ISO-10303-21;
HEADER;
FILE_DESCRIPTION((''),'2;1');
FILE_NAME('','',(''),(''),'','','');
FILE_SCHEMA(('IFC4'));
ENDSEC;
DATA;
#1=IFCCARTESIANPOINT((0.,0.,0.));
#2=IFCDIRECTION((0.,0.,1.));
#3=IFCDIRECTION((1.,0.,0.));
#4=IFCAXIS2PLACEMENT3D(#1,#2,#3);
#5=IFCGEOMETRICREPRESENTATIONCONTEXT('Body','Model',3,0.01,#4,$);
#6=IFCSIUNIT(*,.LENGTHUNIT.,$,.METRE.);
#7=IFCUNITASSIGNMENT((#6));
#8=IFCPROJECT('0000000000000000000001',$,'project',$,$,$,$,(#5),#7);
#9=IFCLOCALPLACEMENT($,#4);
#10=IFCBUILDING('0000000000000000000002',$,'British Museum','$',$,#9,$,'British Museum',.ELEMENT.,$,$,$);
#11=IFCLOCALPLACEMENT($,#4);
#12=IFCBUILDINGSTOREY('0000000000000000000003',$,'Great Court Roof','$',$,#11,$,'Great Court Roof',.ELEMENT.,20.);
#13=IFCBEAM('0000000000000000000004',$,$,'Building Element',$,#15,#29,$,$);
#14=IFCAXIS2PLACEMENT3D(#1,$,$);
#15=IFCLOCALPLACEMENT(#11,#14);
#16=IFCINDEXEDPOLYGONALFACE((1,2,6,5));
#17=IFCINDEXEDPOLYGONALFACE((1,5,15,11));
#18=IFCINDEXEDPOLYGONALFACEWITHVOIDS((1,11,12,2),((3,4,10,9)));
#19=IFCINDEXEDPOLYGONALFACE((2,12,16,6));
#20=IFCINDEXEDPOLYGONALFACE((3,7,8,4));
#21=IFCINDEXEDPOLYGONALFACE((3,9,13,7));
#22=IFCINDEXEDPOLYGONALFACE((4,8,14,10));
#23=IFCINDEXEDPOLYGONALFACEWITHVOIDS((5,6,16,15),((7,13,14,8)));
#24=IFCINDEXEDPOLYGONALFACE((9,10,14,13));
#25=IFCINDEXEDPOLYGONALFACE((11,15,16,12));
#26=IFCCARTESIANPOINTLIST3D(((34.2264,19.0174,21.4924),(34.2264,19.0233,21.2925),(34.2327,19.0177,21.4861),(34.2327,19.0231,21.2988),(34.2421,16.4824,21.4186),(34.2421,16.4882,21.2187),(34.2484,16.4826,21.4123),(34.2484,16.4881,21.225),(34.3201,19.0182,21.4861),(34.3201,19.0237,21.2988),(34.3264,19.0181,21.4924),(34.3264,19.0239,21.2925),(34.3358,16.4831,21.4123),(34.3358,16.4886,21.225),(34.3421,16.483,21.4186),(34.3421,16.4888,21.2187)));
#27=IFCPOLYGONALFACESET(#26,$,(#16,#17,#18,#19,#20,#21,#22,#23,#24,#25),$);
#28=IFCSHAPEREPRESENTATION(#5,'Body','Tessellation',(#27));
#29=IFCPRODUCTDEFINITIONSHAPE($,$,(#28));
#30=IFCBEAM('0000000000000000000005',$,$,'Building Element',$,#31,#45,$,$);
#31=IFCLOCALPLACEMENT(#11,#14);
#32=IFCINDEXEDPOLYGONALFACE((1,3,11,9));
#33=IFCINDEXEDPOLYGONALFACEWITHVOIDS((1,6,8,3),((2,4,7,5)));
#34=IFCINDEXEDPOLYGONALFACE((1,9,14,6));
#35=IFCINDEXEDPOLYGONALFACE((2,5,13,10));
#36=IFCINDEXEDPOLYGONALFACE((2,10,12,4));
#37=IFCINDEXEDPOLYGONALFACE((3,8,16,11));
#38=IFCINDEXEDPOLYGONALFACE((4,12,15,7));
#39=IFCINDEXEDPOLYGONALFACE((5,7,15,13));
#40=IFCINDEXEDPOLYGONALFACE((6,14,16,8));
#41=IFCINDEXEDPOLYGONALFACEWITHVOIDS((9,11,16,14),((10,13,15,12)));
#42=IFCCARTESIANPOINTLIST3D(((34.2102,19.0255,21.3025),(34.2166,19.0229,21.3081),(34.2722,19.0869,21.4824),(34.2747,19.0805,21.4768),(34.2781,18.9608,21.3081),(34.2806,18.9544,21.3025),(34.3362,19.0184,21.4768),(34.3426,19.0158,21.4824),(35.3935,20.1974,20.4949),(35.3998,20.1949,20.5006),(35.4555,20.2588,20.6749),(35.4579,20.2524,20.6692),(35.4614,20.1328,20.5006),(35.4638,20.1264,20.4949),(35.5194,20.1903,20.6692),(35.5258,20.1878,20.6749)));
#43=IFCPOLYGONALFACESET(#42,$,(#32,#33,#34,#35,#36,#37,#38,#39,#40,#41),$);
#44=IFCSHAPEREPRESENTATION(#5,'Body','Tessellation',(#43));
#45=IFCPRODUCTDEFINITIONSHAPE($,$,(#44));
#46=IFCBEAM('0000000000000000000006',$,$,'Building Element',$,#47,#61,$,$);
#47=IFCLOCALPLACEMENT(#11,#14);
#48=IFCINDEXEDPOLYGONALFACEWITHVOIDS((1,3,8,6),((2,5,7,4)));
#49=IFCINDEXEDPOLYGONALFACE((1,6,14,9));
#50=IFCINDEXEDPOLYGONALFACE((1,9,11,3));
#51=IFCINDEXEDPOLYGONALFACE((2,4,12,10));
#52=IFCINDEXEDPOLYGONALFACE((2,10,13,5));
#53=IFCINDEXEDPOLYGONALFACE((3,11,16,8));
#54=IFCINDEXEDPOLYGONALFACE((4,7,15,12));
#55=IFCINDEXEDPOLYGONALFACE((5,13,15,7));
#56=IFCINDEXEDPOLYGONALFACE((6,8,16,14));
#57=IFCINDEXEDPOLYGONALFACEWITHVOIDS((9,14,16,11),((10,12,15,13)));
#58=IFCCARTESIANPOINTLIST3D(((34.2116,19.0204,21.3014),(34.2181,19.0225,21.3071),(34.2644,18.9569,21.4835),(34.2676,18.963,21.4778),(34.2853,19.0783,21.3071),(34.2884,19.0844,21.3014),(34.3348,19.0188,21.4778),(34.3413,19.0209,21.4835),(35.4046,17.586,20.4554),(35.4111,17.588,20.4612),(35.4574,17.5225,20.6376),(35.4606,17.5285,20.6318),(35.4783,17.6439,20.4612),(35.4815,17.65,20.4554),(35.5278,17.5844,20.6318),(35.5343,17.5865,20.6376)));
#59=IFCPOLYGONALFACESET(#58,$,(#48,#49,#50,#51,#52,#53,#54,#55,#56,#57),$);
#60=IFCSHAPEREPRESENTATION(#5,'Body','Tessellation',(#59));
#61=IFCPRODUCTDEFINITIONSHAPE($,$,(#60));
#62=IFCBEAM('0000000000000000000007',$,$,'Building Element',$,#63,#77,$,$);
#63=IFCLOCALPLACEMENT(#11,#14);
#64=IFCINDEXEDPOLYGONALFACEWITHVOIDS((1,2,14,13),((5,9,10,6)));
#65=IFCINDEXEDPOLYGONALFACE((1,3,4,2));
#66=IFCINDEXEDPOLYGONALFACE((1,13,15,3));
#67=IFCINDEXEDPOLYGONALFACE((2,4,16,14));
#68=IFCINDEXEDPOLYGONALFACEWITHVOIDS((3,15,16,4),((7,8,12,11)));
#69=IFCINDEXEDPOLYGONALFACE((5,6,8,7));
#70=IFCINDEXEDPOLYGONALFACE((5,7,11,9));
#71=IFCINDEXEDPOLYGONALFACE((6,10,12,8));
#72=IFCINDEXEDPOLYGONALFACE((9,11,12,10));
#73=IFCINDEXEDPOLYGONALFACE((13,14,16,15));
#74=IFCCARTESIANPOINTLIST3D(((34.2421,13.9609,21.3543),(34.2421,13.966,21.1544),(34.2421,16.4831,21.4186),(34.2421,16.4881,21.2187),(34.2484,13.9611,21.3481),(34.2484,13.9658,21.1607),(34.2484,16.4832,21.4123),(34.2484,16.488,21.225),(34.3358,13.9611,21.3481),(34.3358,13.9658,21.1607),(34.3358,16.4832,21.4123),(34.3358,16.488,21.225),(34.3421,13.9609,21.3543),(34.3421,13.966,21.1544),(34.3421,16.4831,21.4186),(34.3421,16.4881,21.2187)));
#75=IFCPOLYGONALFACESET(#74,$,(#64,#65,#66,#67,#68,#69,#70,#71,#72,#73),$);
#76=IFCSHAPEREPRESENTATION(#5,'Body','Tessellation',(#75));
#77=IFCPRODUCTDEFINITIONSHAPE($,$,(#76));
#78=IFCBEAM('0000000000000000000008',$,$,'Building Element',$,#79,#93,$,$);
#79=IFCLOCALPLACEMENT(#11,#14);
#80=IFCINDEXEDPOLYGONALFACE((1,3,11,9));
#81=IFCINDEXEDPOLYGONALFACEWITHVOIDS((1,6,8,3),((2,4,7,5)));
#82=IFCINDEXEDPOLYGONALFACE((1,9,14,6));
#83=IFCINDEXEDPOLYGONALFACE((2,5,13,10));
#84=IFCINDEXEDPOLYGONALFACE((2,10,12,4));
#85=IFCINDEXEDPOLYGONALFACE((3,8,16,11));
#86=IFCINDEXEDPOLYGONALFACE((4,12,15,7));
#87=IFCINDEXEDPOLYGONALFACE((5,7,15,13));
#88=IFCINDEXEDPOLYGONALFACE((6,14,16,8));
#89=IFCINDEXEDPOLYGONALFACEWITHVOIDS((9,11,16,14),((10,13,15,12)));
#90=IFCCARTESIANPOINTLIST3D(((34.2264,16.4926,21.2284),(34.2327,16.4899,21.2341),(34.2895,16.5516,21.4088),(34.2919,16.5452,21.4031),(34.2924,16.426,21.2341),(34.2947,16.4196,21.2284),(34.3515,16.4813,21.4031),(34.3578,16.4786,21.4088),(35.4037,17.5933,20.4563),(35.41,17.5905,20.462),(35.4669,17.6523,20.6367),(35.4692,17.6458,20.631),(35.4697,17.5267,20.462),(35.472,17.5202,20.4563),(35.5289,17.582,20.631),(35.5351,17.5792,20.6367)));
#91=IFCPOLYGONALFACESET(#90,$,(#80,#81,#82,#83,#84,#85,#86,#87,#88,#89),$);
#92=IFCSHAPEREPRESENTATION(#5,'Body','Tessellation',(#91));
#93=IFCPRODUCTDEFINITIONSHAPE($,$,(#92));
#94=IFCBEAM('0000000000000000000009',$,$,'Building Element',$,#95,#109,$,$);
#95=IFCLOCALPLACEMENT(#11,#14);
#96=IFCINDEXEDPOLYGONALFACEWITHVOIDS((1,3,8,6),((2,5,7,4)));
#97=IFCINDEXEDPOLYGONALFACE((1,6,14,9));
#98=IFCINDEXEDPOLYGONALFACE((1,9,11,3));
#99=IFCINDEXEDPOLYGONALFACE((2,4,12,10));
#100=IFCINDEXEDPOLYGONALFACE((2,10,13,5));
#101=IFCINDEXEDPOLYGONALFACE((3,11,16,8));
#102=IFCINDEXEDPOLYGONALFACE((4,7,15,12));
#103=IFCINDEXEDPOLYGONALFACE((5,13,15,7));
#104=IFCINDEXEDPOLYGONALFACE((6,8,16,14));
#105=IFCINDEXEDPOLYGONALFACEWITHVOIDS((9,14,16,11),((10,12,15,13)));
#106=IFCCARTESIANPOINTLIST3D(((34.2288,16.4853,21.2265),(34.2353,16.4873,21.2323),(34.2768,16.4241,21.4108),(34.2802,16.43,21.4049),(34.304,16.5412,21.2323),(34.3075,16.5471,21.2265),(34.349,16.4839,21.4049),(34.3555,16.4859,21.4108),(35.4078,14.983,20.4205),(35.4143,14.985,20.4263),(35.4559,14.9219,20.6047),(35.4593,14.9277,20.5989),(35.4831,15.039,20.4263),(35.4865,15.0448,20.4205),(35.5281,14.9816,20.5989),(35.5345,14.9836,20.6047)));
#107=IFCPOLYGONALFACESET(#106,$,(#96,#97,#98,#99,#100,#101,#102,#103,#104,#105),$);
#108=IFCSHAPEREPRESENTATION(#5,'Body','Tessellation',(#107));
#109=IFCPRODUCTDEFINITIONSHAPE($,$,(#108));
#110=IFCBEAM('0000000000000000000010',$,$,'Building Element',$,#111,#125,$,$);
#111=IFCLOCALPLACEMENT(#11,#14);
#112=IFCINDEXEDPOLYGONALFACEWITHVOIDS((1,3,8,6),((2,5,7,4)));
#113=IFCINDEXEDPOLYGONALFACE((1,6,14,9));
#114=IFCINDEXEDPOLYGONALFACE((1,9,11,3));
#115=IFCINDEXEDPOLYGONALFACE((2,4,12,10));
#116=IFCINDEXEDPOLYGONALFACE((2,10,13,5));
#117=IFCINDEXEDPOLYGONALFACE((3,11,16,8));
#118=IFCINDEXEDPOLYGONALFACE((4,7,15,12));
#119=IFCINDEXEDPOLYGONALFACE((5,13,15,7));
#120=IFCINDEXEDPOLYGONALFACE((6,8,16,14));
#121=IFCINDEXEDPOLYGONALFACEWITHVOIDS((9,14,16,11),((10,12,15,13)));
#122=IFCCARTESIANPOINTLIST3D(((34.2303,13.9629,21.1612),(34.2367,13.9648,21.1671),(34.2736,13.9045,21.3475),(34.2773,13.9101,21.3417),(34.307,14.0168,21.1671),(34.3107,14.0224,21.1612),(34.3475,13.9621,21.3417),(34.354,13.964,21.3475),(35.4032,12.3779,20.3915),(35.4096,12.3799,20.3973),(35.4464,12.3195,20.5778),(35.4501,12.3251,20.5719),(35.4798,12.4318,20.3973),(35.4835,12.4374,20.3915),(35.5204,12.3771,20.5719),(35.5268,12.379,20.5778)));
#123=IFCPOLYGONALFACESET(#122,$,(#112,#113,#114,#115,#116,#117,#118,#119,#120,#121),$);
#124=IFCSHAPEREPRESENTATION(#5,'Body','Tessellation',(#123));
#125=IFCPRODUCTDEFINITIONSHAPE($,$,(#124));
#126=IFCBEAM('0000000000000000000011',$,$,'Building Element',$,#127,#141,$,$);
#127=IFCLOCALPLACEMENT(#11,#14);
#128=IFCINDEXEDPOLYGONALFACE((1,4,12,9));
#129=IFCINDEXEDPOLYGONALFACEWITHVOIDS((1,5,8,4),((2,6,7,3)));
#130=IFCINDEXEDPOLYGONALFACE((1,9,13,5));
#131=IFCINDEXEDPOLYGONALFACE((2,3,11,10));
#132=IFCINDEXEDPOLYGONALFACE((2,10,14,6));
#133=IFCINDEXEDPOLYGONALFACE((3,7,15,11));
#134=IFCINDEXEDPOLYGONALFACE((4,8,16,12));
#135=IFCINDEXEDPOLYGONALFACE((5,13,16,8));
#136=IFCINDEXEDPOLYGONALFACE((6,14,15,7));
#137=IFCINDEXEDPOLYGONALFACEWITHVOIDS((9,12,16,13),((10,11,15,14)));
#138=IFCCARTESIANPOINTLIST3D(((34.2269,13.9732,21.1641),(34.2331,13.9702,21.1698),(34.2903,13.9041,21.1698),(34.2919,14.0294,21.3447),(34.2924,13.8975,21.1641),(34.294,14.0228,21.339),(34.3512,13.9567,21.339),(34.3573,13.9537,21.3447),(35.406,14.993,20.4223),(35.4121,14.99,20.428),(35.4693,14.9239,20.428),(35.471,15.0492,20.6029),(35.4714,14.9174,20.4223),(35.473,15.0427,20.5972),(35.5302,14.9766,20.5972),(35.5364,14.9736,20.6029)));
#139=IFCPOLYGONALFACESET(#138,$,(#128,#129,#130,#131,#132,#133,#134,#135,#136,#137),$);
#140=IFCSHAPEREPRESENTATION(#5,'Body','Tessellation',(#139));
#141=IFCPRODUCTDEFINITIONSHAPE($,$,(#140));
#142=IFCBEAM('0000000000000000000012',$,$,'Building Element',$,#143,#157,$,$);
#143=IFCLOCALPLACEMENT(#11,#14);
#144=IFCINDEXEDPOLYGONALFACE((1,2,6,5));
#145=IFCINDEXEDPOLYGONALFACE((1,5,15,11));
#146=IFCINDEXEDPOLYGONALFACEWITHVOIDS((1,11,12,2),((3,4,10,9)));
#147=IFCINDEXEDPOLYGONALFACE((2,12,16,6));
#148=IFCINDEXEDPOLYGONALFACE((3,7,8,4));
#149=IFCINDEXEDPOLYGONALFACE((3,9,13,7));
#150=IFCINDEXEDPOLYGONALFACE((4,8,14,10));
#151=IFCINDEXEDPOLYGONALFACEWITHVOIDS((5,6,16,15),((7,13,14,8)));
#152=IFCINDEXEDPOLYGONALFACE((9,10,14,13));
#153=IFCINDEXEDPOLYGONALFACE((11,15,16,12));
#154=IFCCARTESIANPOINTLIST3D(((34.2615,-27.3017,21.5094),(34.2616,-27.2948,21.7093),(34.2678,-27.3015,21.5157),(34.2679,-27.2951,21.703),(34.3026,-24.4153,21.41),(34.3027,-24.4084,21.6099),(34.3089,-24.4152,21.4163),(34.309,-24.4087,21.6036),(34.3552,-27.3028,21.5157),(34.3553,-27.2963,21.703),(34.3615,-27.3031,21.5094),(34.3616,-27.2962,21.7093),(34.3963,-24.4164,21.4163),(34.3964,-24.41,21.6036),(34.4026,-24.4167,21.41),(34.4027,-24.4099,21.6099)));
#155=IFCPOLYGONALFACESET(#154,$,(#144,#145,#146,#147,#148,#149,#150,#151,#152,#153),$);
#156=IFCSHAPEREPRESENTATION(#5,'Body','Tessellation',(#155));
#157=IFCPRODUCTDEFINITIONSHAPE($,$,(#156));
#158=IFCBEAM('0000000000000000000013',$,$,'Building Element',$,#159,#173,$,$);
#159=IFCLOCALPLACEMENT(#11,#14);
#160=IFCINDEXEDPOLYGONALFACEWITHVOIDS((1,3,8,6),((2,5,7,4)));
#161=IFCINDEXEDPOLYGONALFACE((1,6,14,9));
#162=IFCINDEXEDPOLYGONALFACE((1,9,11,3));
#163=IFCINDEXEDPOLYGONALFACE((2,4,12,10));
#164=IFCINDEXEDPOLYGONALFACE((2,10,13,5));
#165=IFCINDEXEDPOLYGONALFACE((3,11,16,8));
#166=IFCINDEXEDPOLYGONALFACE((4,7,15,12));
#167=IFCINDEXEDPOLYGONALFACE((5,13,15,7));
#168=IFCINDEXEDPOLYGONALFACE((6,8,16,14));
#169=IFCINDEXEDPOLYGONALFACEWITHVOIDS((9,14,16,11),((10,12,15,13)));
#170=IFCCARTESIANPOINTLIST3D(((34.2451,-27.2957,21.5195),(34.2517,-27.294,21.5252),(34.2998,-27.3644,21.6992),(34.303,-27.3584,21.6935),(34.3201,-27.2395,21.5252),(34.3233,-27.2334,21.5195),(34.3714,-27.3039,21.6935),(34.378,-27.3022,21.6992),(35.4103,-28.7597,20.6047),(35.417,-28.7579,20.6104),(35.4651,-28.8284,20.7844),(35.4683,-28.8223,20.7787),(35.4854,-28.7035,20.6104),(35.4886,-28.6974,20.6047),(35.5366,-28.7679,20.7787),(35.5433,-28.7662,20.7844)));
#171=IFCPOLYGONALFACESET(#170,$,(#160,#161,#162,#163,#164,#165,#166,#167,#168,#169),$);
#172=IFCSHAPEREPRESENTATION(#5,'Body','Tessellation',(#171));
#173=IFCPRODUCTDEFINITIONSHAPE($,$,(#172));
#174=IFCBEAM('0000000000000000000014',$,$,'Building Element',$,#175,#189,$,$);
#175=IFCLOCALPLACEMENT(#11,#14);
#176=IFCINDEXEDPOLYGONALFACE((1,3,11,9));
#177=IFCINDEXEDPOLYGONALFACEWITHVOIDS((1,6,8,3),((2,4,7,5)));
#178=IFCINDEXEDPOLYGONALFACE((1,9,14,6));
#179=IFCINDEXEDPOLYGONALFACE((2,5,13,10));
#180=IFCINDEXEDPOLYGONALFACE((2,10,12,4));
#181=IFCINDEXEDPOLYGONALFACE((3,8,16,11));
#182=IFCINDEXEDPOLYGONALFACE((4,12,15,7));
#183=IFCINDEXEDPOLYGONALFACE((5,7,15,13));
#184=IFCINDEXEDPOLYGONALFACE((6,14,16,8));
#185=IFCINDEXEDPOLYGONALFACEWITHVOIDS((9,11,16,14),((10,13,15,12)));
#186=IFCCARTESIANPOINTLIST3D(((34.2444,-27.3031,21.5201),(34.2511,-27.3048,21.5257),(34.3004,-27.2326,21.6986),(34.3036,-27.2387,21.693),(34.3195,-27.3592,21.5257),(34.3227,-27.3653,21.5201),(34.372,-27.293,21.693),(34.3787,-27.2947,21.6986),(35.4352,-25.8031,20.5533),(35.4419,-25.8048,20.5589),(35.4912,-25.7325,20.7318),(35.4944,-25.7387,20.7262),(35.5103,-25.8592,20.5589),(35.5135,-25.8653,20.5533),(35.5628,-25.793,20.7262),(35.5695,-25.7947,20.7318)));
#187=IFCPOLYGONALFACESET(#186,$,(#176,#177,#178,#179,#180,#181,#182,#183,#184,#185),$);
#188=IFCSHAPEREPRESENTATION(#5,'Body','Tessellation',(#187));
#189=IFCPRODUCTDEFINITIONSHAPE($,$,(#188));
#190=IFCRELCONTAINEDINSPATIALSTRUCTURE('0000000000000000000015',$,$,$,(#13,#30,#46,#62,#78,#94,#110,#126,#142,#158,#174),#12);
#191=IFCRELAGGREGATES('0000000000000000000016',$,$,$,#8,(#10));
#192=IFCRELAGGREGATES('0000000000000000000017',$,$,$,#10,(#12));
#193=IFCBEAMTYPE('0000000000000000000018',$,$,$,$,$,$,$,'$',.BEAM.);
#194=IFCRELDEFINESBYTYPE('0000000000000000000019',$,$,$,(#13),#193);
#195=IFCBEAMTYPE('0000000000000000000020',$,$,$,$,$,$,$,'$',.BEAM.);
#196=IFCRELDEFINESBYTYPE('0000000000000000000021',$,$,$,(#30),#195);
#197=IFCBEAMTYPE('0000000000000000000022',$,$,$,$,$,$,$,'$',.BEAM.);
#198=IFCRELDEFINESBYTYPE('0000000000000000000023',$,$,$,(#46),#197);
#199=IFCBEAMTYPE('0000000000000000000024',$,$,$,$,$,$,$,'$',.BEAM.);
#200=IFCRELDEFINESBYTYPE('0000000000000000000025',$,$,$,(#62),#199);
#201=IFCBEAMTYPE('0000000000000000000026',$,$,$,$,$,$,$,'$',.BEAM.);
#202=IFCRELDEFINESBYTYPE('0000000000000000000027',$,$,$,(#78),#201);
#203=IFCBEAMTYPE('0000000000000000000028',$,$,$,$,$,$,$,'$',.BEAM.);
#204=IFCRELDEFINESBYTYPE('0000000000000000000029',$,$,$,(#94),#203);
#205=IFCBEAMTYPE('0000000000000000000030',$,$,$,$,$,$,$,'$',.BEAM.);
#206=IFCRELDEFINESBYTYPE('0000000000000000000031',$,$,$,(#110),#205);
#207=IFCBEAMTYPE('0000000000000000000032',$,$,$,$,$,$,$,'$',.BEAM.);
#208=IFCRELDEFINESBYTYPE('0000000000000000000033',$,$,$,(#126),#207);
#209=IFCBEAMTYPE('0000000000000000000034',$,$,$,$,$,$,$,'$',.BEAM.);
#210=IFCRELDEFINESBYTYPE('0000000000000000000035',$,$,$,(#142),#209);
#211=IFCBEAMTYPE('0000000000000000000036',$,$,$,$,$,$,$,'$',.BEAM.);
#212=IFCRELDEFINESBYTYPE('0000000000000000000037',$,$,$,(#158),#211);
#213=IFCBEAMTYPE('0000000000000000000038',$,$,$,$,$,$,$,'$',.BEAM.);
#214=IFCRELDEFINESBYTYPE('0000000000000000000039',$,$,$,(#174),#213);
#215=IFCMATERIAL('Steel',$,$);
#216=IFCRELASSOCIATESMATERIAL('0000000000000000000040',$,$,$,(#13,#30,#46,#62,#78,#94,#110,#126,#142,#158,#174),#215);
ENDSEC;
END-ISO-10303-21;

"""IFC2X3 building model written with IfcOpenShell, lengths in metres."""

from ifc_helpers import new_model, si_unit, frame, origin_with_axes, origin_2d, place, context, project, spatial, hollow_rectangle, extrude, material, type_object, element, save


model = new_model("IFC2X3")

# Units and contexts
model_context = context("Model", 3, precision=0.01, world=origin_with_axes(), identifier="Body")
ifc_project = project(units=[si_unit("LENGTHUNIT", "METRE")], contexts=[model_context])

# Building, storey
building_placement = place(None, origin_with_axes())
building = spatial("IfcBuilding", under=ifc_project, at=building_placement, Name="British Museum", Description="$", LongName="British Museum", CompositionType="ELEMENT")
storey_placement = place(None, origin_with_axes())
storey = spatial("IfcBuildingStorey", under=building, at=storey_placement, Name="Great Court Roof", Description="$", LongName="Great Court Roof", CompositionType="ELEMENT", Elevation=20.0)

# Beams
ifc_material = material(Name="Steel")
beam_type_1 = type_object("IfcBeamType", ElementType="$", PredefinedType="BEAM")
beam_1_placement = place(None, origin_with_axes())
element("IfcBeam", 1, at=beam_1_placement, inside=storey, type_object=beam_type_1, material=ifc_material, Description="Building Element", context=model_context, shape_type="SweptSolid", body=[
    extrude(hollow_rectangle(XDim=0.1, YDim=0.2, WallThickness=0.0063, InnerFilletRadius=-0.0063, OuterFilletRadius=0.0, at=origin_2d()), frame((34.2764, 19.0207, 21.3924), z_axis=(0.006196, -0.999557, -0.029107), x_axis=(0.999981, 0.006198, 0.0)), (0.0, 0.0, 1.0), 2.5362),
])
beam_type_2 = type_object("IfcBeamType", ElementType="$", PredefinedType="BEAM")
beam_2_placement = place(None, origin_with_axes())
element("IfcBeam", 2, at=beam_2_placement, inside=storey, type_object=beam_type_2, material=ifc_material, Description="Building Element", context=model_context, shape_type="SweptSolid", body=[
    extrude(hollow_rectangle(XDim=0.1, YDim=0.2, WallThickness=0.0063, InnerFilletRadius=-0.0063, OuterFilletRadius=0.0, at=origin_2d()), frame((34.2764, 19.0207, 21.3924), z_axis=(0.639296, 0.633198, -0.436304), x_axis=(-0.70371, 0.710487, 0.0)), (0.0, 0.0, 1.0), 1.8508),
])
beam_type_3 = type_object("IfcBeamType", ElementType="$", PredefinedType="BEAM")
beam_3_placement = place(None, origin_with_axes())
element("IfcBeam", 3, at=beam_3_placement, inside=storey, type_object=beam_type_3, material=ifc_material, Description="Building Element", context=model_context, shape_type="SweptSolid", body=[
    extrude(hollow_rectangle(XDim=0.1, YDim=0.2, WallThickness=0.0063, InnerFilletRadius=-0.0063, OuterFilletRadius=0.0, at=origin_2d()), frame((34.2764, 19.0207, 21.3924), z_axis=(0.582379, -0.700216, -0.412956), x_axis=(0.768833, 0.639449, 0.0)), (0.0, 0.0, 1.0), 2.0485),
])
beam_type_4 = type_object("IfcBeamType", ElementType="$", PredefinedType="BEAM")
beam_4_placement = place(None, origin_with_axes())
element("IfcBeam", 4, at=beam_4_placement, inside=storey, type_object=beam_type_4, material=ifc_material, Description="Building Element", context=model_context, shape_type="SweptSolid", body=[
    extrude(hollow_rectangle(XDim=0.1, YDim=0.2, WallThickness=0.0063, InnerFilletRadius=-0.0063, OuterFilletRadius=0.0, at=origin_2d()), frame((34.2921, 16.4856, 21.3186), z_axis=(0.000006, -0.999676, -0.025463), x_axis=(1.0, 0.000006, 0.0)), (0.0, 0.0, 1.0), 2.523),
])
beam_type_5 = type_object("IfcBeamType", ElementType="$", PredefinedType="BEAM")
beam_5_placement = place(None, origin_with_axes())
element("IfcBeam", 5, at=beam_5_placement, inside=storey, type_object=beam_type_5, material=ifc_material, Description="Building Element", context=model_context, shape_type="SweptSolid", body=[
    extrude(hollow_rectangle(XDim=0.1, YDim=0.2, WallThickness=0.0063, InnerFilletRadius=-0.0063, OuterFilletRadius=0.0, at=origin_2d()), frame((34.2921, 16.4856, 21.3186), z_axis=(0.658793, 0.615882, -0.432066), x_axis=(-0.682916, 0.730497, 0.0)), (0.0, 0.0, 1.0), 1.7871),
])
beam_type_6 = type_object("IfcBeamType", ElementType="$", PredefinedType="BEAM")
beam_6_placement = place(None, origin_with_axes())
element("IfcBeam", 6, at=beam_6_placement, inside=storey, type_object=beam_type_6, material=ifc_material, Description="Building Element", context=model_context, shape_type="SweptSolid", body=[
    extrude(hollow_rectangle(XDim=0.1, YDim=0.2, WallThickness=0.0063, InnerFilletRadius=-0.0063, OuterFilletRadius=0.0, at=origin_2d()), frame((34.2921, 16.4856, 21.3186), z_axis=(0.568809, -0.724741, -0.388852), x_axis=(0.786651, 0.617398, 0.0)), (0.0, 0.0, 1.0), 2.0729),
])
beam_type_7 = type_object("IfcBeamType", ElementType="$", PredefinedType="BEAM")
beam_7_placement = place(None, origin_with_axes())
element("IfcBeam", 7, at=beam_7_placement, inside=storey, type_object=beam_type_7, material=ifc_material, Description="Building Element", context=model_context, shape_type="SweptSolid", body=[
    extrude(hollow_rectangle(XDim=0.1, YDim=0.2, WallThickness=0.0063, InnerFilletRadius=-0.0063, OuterFilletRadius=0.0, at=origin_2d()), frame((34.2921, 13.9634, 21.2544), z_axis=(0.554097, -0.748813, -0.36367), x_axis=(0.803855, 0.594826, 0.0)), (0.0, 0.0, 1.0), 2.1167),
])
beam_type_8 = type_object("IfcBeamType", ElementType="$", PredefinedType="BEAM")
beam_8_placement = place(None, origin_with_axes())
element("IfcBeam", 8, at=beam_8_placement, inside=storey, type_object=beam_type_8, material=ifc_material, Description="Building Element", context=model_context, shape_type="SweptSolid", body=[
    extrude(hollow_rectangle(XDim=0.1, YDim=0.2, WallThickness=0.0063, InnerFilletRadius=-0.0063, OuterFilletRadius=0.0, at=origin_2d()), frame((34.2921, 13.9634, 21.2544), z_axis=(0.68294, 0.590743, -0.429669), x_axis=(-0.65421, 0.756313, 0.0)), (0.0, 0.0, 1.0), 1.7264),
])
beam_type_9 = type_object("IfcBeamType", ElementType="$", PredefinedType="BEAM")
beam_9_placement = place(None, origin_with_axes())
element("IfcBeam", 9, at=beam_9_placement, inside=storey, type_object=beam_type_9, material=ifc_material, Description="Building Element", context=model_context, shape_type="SweptSolid", body=[
    extrude(hollow_rectangle(XDim=0.1, YDim=0.2, WallThickness=0.0063, InnerFilletRadius=-0.0063, OuterFilletRadius=0.0, at=origin_2d()), frame((34.3115, -27.2989, 21.6094), z_axis=(0.014241, 0.999306, -0.03442), x_axis=(-0.999898, 0.01425, 0.0)), (0.0, 0.0, 1.0), 2.8884),
])
beam_type_10 = type_object("IfcBeamType", ElementType="$", PredefinedType="BEAM")
beam_10_placement = place(None, origin_with_axes())
element("IfcBeam", 10, at=beam_10_placement, inside=storey, type_object=beam_type_10, material=ifc_material, Description="Building Element", context=model_context, shape_type="SweptSolid", body=[
    extrude(hollow_rectangle(XDim=0.1, YDim=0.2, WallThickness=0.0063, InnerFilletRadius=-0.0063, OuterFilletRadius=0.0, at=origin_2d()), frame((34.3115, -27.2989, 21.6094), z_axis=(0.559474, -0.702897, -0.439233), x_axis=(0.78241, 0.622763, 0.0)), (0.0, 0.0, 1.0), 2.0828),
])
beam_type_11 = type_object("IfcBeamType", ElementType="$", PredefinedType="BEAM")
beam_11_placement = place(None, origin_with_axes())
element("IfcBeam", 11, at=beam_11_placement, inside=storey, type_object=beam_type_11, material=ifc_material, Description="Building Element", context=model_context, shape_type="SweptSolid", body=[
    extrude(hollow_rectangle(XDim=0.1, YDim=0.2, WallThickness=0.0063, InnerFilletRadius=-0.0063, OuterFilletRadius=0.0, at=origin_2d()), frame((34.3115, -27.2989, 21.6094), z_axis=(0.555046, 0.69917, -0.450649), x_axis=(-0.783207, 0.621761, 0.0)), (0.0, 0.0, 1.0), 2.1454),
])

save(model, "model.ifc")
